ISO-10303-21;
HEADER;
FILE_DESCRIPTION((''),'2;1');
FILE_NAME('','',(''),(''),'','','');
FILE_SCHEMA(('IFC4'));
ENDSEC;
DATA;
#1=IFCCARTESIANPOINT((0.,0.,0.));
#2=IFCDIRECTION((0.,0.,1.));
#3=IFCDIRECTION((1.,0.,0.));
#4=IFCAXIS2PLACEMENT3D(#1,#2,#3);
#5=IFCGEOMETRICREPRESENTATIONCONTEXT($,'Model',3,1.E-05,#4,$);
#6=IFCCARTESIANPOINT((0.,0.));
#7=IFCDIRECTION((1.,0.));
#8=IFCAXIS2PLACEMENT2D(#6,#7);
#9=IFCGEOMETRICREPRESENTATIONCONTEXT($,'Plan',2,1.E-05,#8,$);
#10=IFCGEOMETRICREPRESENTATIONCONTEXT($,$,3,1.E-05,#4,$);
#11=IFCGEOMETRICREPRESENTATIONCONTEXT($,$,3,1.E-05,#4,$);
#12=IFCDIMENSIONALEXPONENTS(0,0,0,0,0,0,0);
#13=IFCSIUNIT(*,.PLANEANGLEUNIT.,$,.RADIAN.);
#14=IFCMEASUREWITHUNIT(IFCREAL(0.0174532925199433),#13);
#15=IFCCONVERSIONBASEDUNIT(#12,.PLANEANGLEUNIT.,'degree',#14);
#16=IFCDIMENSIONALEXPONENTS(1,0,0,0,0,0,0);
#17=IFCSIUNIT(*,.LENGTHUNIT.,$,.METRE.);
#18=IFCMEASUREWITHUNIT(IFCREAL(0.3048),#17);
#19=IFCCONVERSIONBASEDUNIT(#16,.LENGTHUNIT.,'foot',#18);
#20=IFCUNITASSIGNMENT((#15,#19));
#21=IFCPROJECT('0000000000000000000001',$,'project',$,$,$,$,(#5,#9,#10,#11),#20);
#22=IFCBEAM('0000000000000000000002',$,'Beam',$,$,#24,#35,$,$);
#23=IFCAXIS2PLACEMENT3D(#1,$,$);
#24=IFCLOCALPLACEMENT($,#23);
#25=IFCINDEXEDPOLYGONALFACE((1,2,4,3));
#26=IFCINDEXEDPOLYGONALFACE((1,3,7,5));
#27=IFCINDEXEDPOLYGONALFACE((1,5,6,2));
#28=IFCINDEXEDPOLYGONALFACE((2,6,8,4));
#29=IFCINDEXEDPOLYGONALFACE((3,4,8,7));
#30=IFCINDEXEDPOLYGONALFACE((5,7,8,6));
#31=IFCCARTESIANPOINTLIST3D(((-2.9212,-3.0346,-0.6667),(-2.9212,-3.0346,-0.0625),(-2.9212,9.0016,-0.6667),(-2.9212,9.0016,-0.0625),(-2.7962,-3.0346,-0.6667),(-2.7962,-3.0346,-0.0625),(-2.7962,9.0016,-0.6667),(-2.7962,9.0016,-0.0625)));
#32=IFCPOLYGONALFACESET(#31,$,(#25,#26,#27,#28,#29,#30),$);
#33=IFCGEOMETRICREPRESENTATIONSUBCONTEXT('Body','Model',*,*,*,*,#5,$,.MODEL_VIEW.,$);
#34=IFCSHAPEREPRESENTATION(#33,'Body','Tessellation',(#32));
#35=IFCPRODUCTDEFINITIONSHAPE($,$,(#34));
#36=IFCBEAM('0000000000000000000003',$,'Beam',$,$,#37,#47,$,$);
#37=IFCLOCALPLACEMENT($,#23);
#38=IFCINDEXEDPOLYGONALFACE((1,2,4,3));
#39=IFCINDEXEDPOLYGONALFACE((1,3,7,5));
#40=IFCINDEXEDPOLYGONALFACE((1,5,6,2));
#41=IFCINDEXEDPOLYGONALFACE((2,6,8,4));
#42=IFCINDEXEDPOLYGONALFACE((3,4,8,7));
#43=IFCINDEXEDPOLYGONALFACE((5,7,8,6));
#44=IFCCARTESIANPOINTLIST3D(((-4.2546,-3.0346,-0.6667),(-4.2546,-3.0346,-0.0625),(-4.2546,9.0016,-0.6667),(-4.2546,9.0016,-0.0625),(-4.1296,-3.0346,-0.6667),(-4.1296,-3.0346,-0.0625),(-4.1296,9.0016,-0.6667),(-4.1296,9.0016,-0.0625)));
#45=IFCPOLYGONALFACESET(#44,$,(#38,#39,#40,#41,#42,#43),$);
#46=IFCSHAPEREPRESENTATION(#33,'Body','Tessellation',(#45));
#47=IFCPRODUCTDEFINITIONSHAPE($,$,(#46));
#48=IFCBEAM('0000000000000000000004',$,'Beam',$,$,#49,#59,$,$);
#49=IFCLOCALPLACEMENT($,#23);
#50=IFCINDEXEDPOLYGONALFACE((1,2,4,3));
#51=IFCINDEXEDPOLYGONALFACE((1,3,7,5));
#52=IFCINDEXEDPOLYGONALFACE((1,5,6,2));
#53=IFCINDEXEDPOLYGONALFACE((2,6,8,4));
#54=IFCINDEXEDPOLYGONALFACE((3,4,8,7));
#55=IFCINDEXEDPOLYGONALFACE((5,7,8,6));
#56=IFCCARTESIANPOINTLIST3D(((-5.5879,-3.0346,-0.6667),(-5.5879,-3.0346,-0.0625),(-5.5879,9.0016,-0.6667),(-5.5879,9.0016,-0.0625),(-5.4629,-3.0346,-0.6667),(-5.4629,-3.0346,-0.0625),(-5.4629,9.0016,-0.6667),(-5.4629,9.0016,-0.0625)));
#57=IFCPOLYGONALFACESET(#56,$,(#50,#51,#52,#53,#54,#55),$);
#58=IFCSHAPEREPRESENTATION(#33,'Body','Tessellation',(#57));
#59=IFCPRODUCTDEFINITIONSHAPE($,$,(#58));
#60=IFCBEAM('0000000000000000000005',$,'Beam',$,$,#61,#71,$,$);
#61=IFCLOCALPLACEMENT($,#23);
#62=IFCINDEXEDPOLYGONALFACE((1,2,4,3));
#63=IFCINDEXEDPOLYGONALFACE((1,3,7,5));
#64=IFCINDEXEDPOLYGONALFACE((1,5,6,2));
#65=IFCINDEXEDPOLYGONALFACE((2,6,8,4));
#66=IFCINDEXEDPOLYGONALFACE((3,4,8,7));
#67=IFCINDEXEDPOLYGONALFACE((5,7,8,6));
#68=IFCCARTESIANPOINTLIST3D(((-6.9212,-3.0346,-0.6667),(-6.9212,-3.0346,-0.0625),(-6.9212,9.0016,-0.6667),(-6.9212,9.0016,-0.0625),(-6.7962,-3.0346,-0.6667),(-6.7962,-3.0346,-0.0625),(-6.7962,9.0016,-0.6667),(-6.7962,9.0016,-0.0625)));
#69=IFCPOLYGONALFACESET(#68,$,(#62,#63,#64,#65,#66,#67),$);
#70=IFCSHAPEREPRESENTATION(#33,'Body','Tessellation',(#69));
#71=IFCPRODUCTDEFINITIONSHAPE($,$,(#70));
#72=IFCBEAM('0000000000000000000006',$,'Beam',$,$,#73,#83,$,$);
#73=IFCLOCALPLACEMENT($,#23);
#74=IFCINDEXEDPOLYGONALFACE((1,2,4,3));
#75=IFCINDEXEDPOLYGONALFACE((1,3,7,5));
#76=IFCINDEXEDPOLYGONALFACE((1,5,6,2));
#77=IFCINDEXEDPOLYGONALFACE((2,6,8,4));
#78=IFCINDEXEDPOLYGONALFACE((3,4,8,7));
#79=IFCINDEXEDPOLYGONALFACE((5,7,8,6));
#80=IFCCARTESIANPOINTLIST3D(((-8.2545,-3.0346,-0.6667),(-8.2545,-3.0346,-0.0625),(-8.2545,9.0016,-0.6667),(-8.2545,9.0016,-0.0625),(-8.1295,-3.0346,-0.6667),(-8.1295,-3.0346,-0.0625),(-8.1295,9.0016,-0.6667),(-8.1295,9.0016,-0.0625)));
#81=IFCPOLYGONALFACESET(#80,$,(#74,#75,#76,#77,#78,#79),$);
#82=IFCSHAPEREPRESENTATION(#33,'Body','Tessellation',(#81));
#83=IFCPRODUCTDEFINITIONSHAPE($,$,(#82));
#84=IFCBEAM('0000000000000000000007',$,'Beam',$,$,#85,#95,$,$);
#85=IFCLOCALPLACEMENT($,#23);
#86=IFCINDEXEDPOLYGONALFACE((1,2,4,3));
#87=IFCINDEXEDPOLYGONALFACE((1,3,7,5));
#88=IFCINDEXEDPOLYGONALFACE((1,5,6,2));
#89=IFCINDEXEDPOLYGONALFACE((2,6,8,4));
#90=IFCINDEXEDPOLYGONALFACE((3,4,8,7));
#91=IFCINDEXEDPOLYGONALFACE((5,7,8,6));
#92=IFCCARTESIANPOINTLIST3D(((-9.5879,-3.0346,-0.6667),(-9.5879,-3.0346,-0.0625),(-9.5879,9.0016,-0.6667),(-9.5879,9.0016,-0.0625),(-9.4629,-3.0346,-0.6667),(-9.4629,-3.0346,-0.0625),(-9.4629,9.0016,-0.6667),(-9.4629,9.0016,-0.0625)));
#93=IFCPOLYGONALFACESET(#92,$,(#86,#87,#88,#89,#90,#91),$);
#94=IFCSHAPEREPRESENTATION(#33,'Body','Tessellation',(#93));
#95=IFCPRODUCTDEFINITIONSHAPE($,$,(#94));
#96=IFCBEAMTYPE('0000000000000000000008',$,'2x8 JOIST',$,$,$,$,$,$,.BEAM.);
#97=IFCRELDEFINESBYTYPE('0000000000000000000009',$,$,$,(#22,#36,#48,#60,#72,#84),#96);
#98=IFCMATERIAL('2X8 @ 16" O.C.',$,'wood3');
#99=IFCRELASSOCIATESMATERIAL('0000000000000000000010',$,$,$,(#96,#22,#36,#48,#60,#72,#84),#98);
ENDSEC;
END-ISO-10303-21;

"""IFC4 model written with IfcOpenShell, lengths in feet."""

from ifc_helpers import new_model, entity, si_unit, converted_unit, frame, origin_with_axes, origin_2d_with_axis, place, context, subcontext, project, rectangle, extrude, material, material_profile, profile_set, profile_usage, type_object, element, save


model = new_model("IFC4")

# Units and contexts
model_context = context("Model", 3, precision=1e-05, world=origin_with_axes())
plan_context = context("Plan", 2, precision=1e-05, world=origin_2d_with_axis())
context_of_model_1 = context(None, 3, precision=1e-05, world=origin_with_axes())
context_of_model_2 = context(None, 3, precision=1e-05, world=origin_with_axes())
body_context = subcontext(model_context, "Body", "Model", "MODEL_VIEW")
ifc_project = project(units=[converted_unit("PLANEANGLEUNIT", "degree", entity("IfcReal", 0.0174532925199433), si_unit("PLANEANGLEUNIT", "RADIAN"), dimensions=[0, 0, 0, 0, 0, 0, 0]), converted_unit("LENGTHUNIT", "foot", entity("IfcReal", 0.3048), si_unit("LENGTHUNIT", "METRE"), dimensions=[1, 0, 0, 0, 0, 0, 0])], contexts=[model_context, plan_context, context_of_model_1, context_of_model_2])

# Beams
ifc_material_1 = material(Name="2X8 @ 16\" O.C.", Category="wood3")
ifc_material_profile_1 = material_profile(ifc_material_1, rectangle(XDim=0.125, YDim=0.6042))
ifc_profile_set_1 = profile_set([ifc_material_profile_1])
ifc_profile_usage_1 = profile_usage(ifc_profile_set_1, cardinal=5)
beam_type_1 = type_object("IfcBeamType", Name="2x8 JOIST", PredefinedType="BEAM", material=ifc_profile_set_1)
beam_1_placement = place(None, frame((-2.8587, -3.0346, -0.3646), z_axis=(0.0, 1.0, 0.0), x_axis=(-1.0, 0.0, 0.0)))
element("IfcBeam", 1, at=beam_1_placement, type_object=beam_type_1, material=ifc_profile_usage_1, Name="Beam", context=body_context, shape_type="SweptSolid", body=[
    extrude(rectangle(XDim=0.125, YDim=0.6042), origin_with_axes(), (0.0, 0.0, 1.0), 12.0362),
])
ifc_profile_usage_2 = profile_usage(ifc_profile_set_1, cardinal=5)
beam_2_placement = place(None, frame((-4.1921, -3.0346, -0.3646), z_axis=(0.0, 1.0, 0.0), x_axis=(-1.0, 0.0, 0.0)))
element("IfcBeam", 2, at=beam_2_placement, type_object=beam_type_1, material=ifc_profile_usage_2, Name="Beam", context=body_context, shape_type="SweptSolid", body=[
    extrude(rectangle(XDim=0.125, YDim=0.6042), origin_with_axes(), (0.0, 0.0, 1.0), 12.0362),
])
ifc_profile_usage_3 = profile_usage(ifc_profile_set_1, cardinal=5)
beam_3_placement = place(None, frame((-5.5254, -3.0346, -0.3646), z_axis=(0.0, 1.0, 0.0), x_axis=(-1.0, 0.0, 0.0)))
element("IfcBeam", 3, at=beam_3_placement, type_object=beam_type_1, material=ifc_profile_usage_3, Name="Beam", context=body_context, shape_type="SweptSolid", body=[
    extrude(rectangle(XDim=0.125, YDim=0.6042), origin_with_axes(), (0.0, 0.0, 1.0), 12.0362),
])
ifc_profile_usage_4 = profile_usage(ifc_profile_set_1, cardinal=5)
beam_4_placement = place(None, frame((-6.8587, -3.0346, -0.3646), z_axis=(0.0, 1.0, 0.0), x_axis=(-1.0, 0.0, 0.0)))
element("IfcBeam", 4, at=beam_4_placement, type_object=beam_type_1, material=ifc_profile_usage_4, Name="Beam", context=body_context, shape_type="SweptSolid", body=[
    extrude(rectangle(XDim=0.125, YDim=0.6042), origin_with_axes(), (0.0, 0.0, 1.0), 12.0362),
])
ifc_profile_usage_5 = profile_usage(ifc_profile_set_1, cardinal=5)
beam_5_placement = place(None, frame((-8.192, -3.0346, -0.3646), z_axis=(0.0, 1.0, 0.0), x_axis=(-1.0, 0.0, 0.0)))
element("IfcBeam", 5, at=beam_5_placement, type_object=beam_type_1, material=ifc_profile_usage_5, Name="Beam", context=body_context, shape_type="SweptSolid", body=[
    extrude(rectangle(XDim=0.125, YDim=0.6042), origin_with_axes(), (0.0, 0.0, 1.0), 12.0362),
])
ifc_profile_usage_6 = profile_usage(ifc_profile_set_1, cardinal=5)
beam_6_placement = place(None, frame((-9.5254, -3.0346, -0.3646), z_axis=(0.0, 1.0, 0.0), x_axis=(-1.0, 0.0, 0.0)))
element("IfcBeam", 6, at=beam_6_placement, type_object=beam_type_1, material=ifc_profile_usage_6, Name="Beam", context=body_context, shape_type="SweptSolid", body=[
    extrude(rectangle(XDim=0.125, YDim=0.6042), origin_with_axes(), (0.0, 0.0, 1.0), 12.0362),
])

save(model, "model.ifc")
